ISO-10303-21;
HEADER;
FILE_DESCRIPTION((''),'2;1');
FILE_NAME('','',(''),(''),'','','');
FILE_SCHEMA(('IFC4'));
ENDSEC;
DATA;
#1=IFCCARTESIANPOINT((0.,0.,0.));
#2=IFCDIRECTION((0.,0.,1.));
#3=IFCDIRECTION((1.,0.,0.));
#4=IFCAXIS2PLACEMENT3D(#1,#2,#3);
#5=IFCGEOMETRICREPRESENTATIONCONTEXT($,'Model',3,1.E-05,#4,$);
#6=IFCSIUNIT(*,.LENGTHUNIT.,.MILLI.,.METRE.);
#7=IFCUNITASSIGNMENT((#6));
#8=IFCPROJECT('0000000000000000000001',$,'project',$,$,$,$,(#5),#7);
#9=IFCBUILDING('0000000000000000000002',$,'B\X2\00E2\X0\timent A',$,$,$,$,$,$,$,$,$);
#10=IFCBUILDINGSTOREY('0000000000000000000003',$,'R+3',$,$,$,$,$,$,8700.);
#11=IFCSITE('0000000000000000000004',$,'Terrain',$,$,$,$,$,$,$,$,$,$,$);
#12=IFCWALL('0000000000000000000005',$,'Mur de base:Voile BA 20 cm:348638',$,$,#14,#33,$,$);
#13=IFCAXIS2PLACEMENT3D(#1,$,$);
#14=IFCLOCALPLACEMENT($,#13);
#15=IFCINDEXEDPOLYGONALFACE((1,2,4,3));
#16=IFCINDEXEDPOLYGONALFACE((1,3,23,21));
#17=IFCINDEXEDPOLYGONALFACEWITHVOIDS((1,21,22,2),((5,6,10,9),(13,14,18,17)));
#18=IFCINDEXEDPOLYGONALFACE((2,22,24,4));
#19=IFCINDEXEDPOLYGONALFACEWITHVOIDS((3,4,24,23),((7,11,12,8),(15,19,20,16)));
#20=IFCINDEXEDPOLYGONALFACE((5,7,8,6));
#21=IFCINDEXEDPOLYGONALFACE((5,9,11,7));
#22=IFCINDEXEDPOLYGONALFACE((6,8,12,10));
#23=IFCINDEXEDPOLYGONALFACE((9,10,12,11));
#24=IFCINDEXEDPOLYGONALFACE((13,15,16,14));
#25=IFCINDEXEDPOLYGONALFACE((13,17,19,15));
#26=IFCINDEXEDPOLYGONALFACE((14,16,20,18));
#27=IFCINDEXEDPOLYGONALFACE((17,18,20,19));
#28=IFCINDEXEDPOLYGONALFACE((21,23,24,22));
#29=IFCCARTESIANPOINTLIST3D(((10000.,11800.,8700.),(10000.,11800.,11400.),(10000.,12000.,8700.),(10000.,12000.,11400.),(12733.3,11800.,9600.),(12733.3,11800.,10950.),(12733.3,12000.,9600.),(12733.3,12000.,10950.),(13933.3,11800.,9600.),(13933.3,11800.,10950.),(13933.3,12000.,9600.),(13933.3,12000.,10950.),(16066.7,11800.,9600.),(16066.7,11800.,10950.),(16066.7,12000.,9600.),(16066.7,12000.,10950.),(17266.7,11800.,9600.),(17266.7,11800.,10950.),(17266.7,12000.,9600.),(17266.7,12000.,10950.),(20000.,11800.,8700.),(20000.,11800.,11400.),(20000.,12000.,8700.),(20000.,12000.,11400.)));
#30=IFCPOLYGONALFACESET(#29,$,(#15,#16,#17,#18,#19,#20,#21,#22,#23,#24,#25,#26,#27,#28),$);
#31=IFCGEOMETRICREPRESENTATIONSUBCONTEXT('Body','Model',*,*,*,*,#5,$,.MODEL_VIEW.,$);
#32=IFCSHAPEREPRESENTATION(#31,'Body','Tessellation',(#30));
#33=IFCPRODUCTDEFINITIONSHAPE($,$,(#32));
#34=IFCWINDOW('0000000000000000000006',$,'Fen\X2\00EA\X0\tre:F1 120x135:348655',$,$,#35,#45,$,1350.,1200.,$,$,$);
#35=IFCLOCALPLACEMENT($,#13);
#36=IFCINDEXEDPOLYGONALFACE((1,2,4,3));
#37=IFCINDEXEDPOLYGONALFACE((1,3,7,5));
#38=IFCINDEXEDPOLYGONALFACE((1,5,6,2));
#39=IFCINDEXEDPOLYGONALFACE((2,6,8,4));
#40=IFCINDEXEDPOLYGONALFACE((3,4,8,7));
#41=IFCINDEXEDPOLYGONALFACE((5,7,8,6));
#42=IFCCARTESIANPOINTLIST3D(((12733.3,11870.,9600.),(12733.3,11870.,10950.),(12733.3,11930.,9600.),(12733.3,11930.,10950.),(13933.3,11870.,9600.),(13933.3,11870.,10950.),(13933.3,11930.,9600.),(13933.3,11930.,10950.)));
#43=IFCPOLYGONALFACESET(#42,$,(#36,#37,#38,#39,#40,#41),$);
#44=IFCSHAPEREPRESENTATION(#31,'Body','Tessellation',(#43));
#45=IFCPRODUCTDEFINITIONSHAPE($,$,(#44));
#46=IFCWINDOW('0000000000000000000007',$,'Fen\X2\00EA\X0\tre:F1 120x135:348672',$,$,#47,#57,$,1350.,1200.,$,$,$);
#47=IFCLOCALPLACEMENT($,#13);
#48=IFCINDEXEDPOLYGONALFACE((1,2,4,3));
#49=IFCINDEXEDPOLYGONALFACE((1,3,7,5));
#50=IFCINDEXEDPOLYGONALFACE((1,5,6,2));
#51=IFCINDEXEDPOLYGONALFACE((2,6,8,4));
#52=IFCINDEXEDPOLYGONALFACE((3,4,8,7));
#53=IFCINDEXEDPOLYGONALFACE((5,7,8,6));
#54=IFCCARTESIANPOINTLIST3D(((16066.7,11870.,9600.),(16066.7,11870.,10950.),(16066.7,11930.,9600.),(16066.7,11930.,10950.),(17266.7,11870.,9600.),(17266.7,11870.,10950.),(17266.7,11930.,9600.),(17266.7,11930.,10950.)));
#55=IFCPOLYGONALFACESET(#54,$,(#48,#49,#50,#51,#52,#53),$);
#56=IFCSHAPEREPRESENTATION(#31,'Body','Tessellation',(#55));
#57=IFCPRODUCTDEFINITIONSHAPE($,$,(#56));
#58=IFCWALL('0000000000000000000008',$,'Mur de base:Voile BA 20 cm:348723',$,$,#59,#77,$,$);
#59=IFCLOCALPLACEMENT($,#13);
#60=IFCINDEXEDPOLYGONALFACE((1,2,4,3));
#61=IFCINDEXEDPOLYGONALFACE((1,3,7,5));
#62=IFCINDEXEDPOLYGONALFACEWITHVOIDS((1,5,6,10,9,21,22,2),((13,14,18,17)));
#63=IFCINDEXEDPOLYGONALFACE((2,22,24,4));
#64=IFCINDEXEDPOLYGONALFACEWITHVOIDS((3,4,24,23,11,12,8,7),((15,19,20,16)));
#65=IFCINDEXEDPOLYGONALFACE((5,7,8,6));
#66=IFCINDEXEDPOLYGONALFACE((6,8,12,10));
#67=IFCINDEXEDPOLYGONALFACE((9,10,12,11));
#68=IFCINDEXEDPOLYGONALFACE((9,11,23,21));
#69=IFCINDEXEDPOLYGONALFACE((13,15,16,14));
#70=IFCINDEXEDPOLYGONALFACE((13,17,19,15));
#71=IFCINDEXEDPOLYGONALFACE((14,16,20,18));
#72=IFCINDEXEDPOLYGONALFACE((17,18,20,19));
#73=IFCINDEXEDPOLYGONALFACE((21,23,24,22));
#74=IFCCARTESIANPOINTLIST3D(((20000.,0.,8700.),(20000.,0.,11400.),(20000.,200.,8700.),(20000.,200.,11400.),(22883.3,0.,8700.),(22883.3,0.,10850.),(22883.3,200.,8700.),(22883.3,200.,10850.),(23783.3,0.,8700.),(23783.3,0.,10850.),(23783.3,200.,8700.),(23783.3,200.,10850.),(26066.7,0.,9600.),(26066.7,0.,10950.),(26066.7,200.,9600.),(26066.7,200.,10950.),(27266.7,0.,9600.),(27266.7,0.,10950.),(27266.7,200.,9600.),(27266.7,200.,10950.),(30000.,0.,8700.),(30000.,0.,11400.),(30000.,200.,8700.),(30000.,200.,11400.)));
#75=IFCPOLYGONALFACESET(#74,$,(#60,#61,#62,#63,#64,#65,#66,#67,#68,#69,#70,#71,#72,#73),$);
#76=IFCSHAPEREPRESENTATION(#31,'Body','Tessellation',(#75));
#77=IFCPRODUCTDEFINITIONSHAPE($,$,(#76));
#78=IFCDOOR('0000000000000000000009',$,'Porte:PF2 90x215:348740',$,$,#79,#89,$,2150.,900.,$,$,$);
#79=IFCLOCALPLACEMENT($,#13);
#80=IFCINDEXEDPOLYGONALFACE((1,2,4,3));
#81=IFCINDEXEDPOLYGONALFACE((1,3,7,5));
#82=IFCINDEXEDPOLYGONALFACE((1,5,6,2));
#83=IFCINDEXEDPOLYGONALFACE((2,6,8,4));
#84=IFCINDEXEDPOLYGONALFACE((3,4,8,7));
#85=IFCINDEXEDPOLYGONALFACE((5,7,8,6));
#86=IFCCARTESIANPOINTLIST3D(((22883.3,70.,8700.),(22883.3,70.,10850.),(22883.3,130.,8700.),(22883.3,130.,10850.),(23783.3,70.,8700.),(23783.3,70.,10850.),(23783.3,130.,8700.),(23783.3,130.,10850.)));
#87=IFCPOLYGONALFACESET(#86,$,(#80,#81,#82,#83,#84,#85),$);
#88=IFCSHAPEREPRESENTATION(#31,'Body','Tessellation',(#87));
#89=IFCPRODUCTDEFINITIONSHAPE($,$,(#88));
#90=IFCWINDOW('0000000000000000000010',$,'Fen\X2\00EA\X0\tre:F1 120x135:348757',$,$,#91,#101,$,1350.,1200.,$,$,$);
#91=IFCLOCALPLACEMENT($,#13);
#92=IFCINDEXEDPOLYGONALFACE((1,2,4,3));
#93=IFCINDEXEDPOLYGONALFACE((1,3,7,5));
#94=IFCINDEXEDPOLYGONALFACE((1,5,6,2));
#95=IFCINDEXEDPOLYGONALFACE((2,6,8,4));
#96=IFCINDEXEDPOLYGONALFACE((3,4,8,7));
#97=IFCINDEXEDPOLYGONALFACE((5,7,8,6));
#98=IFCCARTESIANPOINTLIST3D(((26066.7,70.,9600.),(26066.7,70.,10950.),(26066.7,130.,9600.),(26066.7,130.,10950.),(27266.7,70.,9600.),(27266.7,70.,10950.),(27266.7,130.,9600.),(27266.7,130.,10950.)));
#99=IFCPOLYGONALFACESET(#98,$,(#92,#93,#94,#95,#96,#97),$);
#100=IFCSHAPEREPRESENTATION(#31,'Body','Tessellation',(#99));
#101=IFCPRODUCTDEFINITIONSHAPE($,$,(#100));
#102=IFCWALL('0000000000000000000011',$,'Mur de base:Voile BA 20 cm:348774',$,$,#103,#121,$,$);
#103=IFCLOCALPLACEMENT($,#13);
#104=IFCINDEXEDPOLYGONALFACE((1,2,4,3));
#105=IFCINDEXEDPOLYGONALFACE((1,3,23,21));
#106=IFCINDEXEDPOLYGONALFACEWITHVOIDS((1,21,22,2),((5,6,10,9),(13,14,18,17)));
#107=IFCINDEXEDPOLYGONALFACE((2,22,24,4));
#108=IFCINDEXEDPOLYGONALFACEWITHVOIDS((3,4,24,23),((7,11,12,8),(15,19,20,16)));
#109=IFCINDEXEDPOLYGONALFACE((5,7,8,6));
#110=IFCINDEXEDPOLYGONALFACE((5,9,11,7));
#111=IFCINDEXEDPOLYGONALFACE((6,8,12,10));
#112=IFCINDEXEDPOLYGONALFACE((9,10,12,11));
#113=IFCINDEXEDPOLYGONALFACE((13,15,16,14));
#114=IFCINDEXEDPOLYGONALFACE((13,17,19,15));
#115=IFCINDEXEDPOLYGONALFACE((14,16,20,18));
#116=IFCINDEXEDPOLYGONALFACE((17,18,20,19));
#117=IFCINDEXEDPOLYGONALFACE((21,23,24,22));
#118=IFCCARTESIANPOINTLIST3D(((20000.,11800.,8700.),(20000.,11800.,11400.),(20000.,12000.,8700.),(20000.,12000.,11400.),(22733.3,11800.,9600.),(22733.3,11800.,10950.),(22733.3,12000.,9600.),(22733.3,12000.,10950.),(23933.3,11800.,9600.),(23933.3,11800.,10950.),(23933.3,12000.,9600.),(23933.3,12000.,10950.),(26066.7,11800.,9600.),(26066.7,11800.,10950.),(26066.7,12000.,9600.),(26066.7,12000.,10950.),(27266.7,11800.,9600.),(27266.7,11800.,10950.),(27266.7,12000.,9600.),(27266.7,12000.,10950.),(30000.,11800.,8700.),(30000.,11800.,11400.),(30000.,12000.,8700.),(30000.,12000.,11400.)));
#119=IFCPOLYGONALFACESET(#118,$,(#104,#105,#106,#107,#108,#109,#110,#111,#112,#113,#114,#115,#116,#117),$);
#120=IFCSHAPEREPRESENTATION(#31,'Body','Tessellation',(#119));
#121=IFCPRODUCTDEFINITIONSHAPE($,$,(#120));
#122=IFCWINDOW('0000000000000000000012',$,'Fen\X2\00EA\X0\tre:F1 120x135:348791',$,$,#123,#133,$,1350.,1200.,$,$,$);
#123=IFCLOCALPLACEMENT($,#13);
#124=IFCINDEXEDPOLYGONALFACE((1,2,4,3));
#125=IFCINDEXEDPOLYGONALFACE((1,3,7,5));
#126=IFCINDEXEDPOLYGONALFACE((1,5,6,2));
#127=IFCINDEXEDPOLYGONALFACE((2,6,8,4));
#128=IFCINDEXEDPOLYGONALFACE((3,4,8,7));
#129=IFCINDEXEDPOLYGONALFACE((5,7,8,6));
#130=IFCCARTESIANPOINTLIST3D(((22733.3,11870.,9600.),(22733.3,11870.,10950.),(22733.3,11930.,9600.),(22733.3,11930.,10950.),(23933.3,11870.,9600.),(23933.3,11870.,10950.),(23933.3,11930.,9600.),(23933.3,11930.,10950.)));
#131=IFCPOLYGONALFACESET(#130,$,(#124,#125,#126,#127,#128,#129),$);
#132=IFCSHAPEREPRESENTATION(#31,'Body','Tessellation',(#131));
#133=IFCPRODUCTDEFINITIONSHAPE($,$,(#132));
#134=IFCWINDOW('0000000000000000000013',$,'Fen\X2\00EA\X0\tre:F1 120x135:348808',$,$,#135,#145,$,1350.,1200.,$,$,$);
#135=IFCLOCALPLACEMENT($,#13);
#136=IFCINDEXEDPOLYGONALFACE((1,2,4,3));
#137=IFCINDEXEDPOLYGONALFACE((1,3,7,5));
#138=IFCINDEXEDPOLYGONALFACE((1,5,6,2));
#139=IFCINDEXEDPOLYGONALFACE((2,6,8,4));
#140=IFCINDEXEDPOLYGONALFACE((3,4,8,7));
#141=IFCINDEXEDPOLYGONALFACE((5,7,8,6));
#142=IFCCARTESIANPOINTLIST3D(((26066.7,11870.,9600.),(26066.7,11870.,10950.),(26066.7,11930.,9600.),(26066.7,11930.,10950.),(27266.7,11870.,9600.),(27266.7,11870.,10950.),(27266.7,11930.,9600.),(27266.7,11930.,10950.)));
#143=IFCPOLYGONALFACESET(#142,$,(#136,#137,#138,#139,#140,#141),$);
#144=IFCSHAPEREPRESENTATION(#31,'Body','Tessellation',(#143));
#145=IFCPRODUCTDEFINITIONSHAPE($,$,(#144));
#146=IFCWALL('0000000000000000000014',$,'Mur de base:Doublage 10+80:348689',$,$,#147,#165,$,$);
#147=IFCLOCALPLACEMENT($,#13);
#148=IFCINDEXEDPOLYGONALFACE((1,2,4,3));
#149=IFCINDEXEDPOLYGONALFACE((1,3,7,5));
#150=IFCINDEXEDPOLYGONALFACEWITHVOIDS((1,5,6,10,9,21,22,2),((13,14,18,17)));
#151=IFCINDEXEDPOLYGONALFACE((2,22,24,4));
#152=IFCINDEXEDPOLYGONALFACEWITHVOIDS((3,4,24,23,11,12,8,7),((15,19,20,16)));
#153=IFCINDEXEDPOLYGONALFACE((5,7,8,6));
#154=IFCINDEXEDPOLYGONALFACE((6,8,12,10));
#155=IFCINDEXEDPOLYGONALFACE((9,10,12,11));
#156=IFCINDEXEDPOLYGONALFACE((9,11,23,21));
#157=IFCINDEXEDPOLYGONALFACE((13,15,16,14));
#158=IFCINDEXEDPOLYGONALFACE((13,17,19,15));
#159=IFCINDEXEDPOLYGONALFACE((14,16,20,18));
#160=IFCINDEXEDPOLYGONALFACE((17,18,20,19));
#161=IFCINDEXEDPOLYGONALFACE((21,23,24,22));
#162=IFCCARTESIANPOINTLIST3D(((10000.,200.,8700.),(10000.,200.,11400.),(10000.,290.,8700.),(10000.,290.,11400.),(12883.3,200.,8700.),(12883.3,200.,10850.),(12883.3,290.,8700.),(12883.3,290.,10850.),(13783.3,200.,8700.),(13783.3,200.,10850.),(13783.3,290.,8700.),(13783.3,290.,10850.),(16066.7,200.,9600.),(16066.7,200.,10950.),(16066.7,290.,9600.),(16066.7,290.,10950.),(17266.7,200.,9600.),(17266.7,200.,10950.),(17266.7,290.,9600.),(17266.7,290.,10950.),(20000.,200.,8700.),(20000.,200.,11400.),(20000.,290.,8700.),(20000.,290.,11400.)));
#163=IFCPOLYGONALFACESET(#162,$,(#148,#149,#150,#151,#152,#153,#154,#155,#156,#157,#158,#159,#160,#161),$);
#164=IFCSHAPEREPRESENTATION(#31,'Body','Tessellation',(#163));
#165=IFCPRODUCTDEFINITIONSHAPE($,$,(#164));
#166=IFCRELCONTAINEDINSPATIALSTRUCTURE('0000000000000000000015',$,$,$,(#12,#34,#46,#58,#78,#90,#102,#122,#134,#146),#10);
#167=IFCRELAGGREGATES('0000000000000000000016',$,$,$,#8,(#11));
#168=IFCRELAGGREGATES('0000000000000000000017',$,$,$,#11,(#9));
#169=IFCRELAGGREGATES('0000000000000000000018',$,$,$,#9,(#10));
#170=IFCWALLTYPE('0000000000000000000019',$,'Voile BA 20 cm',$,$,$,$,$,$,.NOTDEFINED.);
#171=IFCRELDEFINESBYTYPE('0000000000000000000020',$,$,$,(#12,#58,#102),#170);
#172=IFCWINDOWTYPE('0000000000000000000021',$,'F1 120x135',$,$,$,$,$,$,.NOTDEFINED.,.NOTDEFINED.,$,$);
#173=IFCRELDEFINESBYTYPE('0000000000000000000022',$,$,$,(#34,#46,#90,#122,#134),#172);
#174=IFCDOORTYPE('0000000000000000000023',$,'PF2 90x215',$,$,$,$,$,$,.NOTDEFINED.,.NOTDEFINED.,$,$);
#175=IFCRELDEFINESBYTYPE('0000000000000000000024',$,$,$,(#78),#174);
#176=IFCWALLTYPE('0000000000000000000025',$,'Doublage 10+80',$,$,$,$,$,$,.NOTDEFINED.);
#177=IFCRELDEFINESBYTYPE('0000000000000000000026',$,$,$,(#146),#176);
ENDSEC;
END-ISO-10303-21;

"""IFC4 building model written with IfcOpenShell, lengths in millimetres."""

from ifc_helpers import new_model, si_unit, frame, frame_2d, origin_with_axes, place, context, subcontext, project, spatial, rectangle, extrude, type_object, element, fill, save


model = new_model("IFC4")

# Units and contexts
model_context = context("Model", 3, precision=1e-05, world=origin_with_axes())
body_context = subcontext(model_context, "Body", "Model", "MODEL_VIEW")
ifc_project = project(units=[si_unit("LENGTHUNIT", "METRE", prefix="MILLI")], contexts=[model_context])

# Site, building, storey
site = spatial("IfcSite", under=ifc_project, Name="Terrain")
building = spatial("IfcBuilding", under=site, Name="Bâtiment A")
storey = spatial("IfcBuildingStorey", under=building, Name="R+3", Elevation=8700.0)

# Wall, openings, windows
wall_type_1 = type_object("IfcWallType", Name="Voile BA 20 cm", PredefinedType="NOTDEFINED")
wall_1_placement = place(None, origin_with_axes())
wall_1 = element("IfcWall", 1, at=wall_1_placement, inside=storey, type_object=wall_type_1, Name="Mur de base:Voile BA 20 cm:348638", context=body_context, shape_type="SweptSolid", body=[
    extrude(rectangle(XDim=10000.0, YDim=200.0, at=frame_2d((15000.0, 11900.0))), frame((0.0, 0.0, 8700.0), z_axis=(0.0, 0.0, 1.0), x_axis=(1.0, 0.0, 0.0)), (0.0, 0.0, 1.0), 2700.0),
])
opening_1_placement = place(None, origin_with_axes())
opening_1 = element("IfcOpeningElement", 2, at=opening_1_placement, cuts=wall_1, context=body_context, shape_type="SweptSolid", body=[
    extrude(rectangle(XDim=1200.0, YDim=320.0, at=frame_2d((13333.3, 11900.0))), frame((0.0, 0.0, 9600.0), z_axis=(0.0, 0.0, 1.0), x_axis=(1.0, 0.0, 0.0)), (0.0, 0.0, 1.0), 1350.0),
])
opening_2_placement = place(None, origin_with_axes())
opening_2 = element("IfcOpeningElement", 3, at=opening_2_placement, cuts=wall_1, context=body_context, shape_type="SweptSolid", body=[
    extrude(rectangle(XDim=1200.0, YDim=320.0, at=frame_2d((16666.7, 11900.0))), frame((0.0, 0.0, 9600.0), z_axis=(0.0, 0.0, 1.0), x_axis=(1.0, 0.0, 0.0)), (0.0, 0.0, 1.0), 1350.0),
])
window_type = type_object("IfcWindowType", Name="F1 120x135", PartitioningType="NOTDEFINED", PredefinedType="NOTDEFINED")
window_1_placement = place(None, origin_with_axes())
window_1 = element("IfcWindow", 4, at=window_1_placement, inside=storey, type_object=window_type, Name="Fenêtre:F1 120x135:348655", OverallHeight=1350.0, OverallWidth=1200.0, context=body_context, shape_type="SweptSolid", body=[
    extrude(rectangle(XDim=1200.0, YDim=60.0, at=frame_2d((13333.3, 11900.0))), frame((0.0, 0.0, 9600.0), z_axis=(0.0, 0.0, 1.0), x_axis=(1.0, 0.0, 0.0)), (0.0, 0.0, 1.0), 1350.0),
])
fill(opening_1, window_1)
window_2_placement = place(None, origin_with_axes())
window_2 = element("IfcWindow", 5, at=window_2_placement, inside=storey, type_object=window_type, Name="Fenêtre:F1 120x135:348672", OverallHeight=1350.0, OverallWidth=1200.0, context=body_context, shape_type="SweptSolid", body=[
    extrude(rectangle(XDim=1200.0, YDim=60.0, at=frame_2d((16666.7, 11900.0))), frame((0.0, 0.0, 9600.0), z_axis=(0.0, 0.0, 1.0), x_axis=(1.0, 0.0, 0.0)), (0.0, 0.0, 1.0), 1350.0),
])
fill(opening_2, window_2)

# Wall, openings, door, window
wall_2_placement = place(None, origin_with_axes())
wall_2 = element("IfcWall", 6, at=wall_2_placement, inside=storey, type_object=wall_type_1, Name="Mur de base:Voile BA 20 cm:348723", context=body_context, shape_type="SweptSolid", body=[
    extrude(rectangle(XDim=10000.0, YDim=200.0, at=frame_2d((25000.0, 100.0))), frame((0.0, 0.0, 8700.0), z_axis=(0.0, 0.0, 1.0), x_axis=(1.0, 0.0, 0.0)), (0.0, 0.0, 1.0), 2700.0),
])
opening_3_placement = place(None, origin_with_axes())
opening_3 = element("IfcOpeningElement", 7, at=opening_3_placement, cuts=wall_2, context=body_context, shape_type="SweptSolid", body=[
    extrude(rectangle(XDim=900.0, YDim=320.0, at=frame_2d((23333.3, 100.0))), frame((0.0, 0.0, 8700.0), z_axis=(0.0, 0.0, 1.0), x_axis=(1.0, 0.0, 0.0)), (0.0, 0.0, 1.0), 2150.0),
])
opening_4_placement = place(None, origin_with_axes())
opening_4 = element("IfcOpeningElement", 8, at=opening_4_placement, cuts=wall_2, context=body_context, shape_type="SweptSolid", body=[
    extrude(rectangle(XDim=1200.0, YDim=320.0, at=frame_2d((26666.7, 100.0))), frame((0.0, 0.0, 9600.0), z_axis=(0.0, 0.0, 1.0), x_axis=(1.0, 0.0, 0.0)), (0.0, 0.0, 1.0), 1350.0),
])
door_type = type_object("IfcDoorType", Name="PF2 90x215", OperationType="NOTDEFINED", PredefinedType="NOTDEFINED")
door_placement = place(None, origin_with_axes())
door = element("IfcDoor", 9, at=door_placement, inside=storey, type_object=door_type, Name="Porte:PF2 90x215:348740", OverallHeight=2150.0, OverallWidth=900.0, context=body_context, shape_type="SweptSolid", body=[
    extrude(rectangle(XDim=900.0, YDim=60.0, at=frame_2d((23333.3, 100.0))), frame((0.0, 0.0, 8700.0), z_axis=(0.0, 0.0, 1.0), x_axis=(1.0, 0.0, 0.0)), (0.0, 0.0, 1.0), 2150.0),
])
fill(opening_3, door)
window_3_placement = place(None, origin_with_axes())
window_3 = element("IfcWindow", 10, at=window_3_placement, inside=storey, type_object=window_type, Name="Fenêtre:F1 120x135:348757", OverallHeight=1350.0, OverallWidth=1200.0, context=body_context, shape_type="SweptSolid", body=[
    extrude(rectangle(XDim=1200.0, YDim=60.0, at=frame_2d((26666.7, 100.0))), frame((0.0, 0.0, 9600.0), z_axis=(0.0, 0.0, 1.0), x_axis=(1.0, 0.0, 0.0)), (0.0, 0.0, 1.0), 1350.0),
])
fill(opening_4, window_3)

# Wall, openings, windows
wall_3_placement = place(None, origin_with_axes())
wall_3 = element("IfcWall", 11, at=wall_3_placement, inside=storey, type_object=wall_type_1, Name="Mur de base:Voile BA 20 cm:348774", context=body_context, shape_type="SweptSolid", body=[
    extrude(rectangle(XDim=10000.0, YDim=200.0, at=frame_2d((25000.0, 11900.0))), frame((0.0, 0.0, 8700.0), z_axis=(0.0, 0.0, 1.0), x_axis=(1.0, 0.0, 0.0)), (0.0, 0.0, 1.0), 2700.0),
])
opening_5_placement = place(None, origin_with_axes())
opening_5 = element("IfcOpeningElement", 12, at=opening_5_placement, cuts=wall_3, context=body_context, shape_type="SweptSolid", body=[
    extrude(rectangle(XDim=1200.0, YDim=320.0, at=frame_2d((23333.3, 11900.0))), frame((0.0, 0.0, 9600.0), z_axis=(0.0, 0.0, 1.0), x_axis=(1.0, 0.0, 0.0)), (0.0, 0.0, 1.0), 1350.0),
])
opening_6_placement = place(None, origin_with_axes())
opening_6 = element("IfcOpeningElement", 13, at=opening_6_placement, cuts=wall_3, context=body_context, shape_type="SweptSolid", body=[
    extrude(rectangle(XDim=1200.0, YDim=320.0, at=frame_2d((26666.7, 11900.0))), frame((0.0, 0.0, 9600.0), z_axis=(0.0, 0.0, 1.0), x_axis=(1.0, 0.0, 0.0)), (0.0, 0.0, 1.0), 1350.0),
])
window_4_placement = place(None, origin_with_axes())
window_4 = element("IfcWindow", 14, at=window_4_placement, inside=storey, type_object=window_type, Name="Fenêtre:F1 120x135:348791", OverallHeight=1350.0, OverallWidth=1200.0, context=body_context, shape_type="SweptSolid", body=[
    extrude(rectangle(XDim=1200.0, YDim=60.0, at=frame_2d((23333.3, 11900.0))), frame((0.0, 0.0, 9600.0), z_axis=(0.0, 0.0, 1.0), x_axis=(1.0, 0.0, 0.0)), (0.0, 0.0, 1.0), 1350.0),
])
fill(opening_5, window_4)
window_5_placement = place(None, origin_with_axes())
window_5 = element("IfcWindow", 15, at=window_5_placement, inside=storey, type_object=window_type, Name="Fenêtre:F1 120x135:348808", OverallHeight=1350.0, OverallWidth=1200.0, context=body_context, shape_type="SweptSolid", body=[
    extrude(rectangle(XDim=1200.0, YDim=60.0, at=frame_2d((26666.7, 11900.0))), frame((0.0, 0.0, 9600.0), z_axis=(0.0, 0.0, 1.0), x_axis=(1.0, 0.0, 0.0)), (0.0, 0.0, 1.0), 1350.0),
])
fill(opening_6, window_5)

# Wall, openings
wall_type_2 = type_object("IfcWallType", Name="Doublage 10+80", PredefinedType="NOTDEFINED")
wall_4_placement = place(None, origin_with_axes())
wall_4 = element("IfcWall", 16, at=wall_4_placement, inside=storey, type_object=wall_type_2, Name="Mur de base:Doublage 10+80:348689", context=body_context, shape_type="SweptSolid", body=[
    extrude(rectangle(XDim=10000.0, YDim=90.0, at=frame_2d((15000.0, 245.0))), frame((0.0, 0.0, 8700.0), z_axis=(0.0, 0.0, 1.0), x_axis=(1.0, 0.0, 0.0)), (0.0, 0.0, 1.0), 2700.0),
])
opening_7_placement = place(None, origin_with_axes())
element("IfcOpeningElement", 17, at=opening_7_placement, cuts=wall_4, context=body_context, shape_type="SweptSolid", body=[
    extrude(rectangle(XDim=900.0, YDim=210.0, at=frame_2d((13333.3, 245.0))), frame((0.0, 0.0, 8700.0), z_axis=(0.0, 0.0, 1.0), x_axis=(1.0, 0.0, 0.0)), (0.0, 0.0, 1.0), 2150.0),
])
opening_8_placement = place(None, origin_with_axes())
element("IfcOpeningElement", 18, at=opening_8_placement, cuts=wall_4, context=body_context, shape_type="SweptSolid", body=[
    extrude(rectangle(XDim=1200.0, YDim=210.0, at=frame_2d((16666.7, 245.0))), frame((0.0, 0.0, 9600.0), z_axis=(0.0, 0.0, 1.0), x_axis=(1.0, 0.0, 0.0)), (0.0, 0.0, 1.0), 1350.0),
])

save(model, "model.ifc")
